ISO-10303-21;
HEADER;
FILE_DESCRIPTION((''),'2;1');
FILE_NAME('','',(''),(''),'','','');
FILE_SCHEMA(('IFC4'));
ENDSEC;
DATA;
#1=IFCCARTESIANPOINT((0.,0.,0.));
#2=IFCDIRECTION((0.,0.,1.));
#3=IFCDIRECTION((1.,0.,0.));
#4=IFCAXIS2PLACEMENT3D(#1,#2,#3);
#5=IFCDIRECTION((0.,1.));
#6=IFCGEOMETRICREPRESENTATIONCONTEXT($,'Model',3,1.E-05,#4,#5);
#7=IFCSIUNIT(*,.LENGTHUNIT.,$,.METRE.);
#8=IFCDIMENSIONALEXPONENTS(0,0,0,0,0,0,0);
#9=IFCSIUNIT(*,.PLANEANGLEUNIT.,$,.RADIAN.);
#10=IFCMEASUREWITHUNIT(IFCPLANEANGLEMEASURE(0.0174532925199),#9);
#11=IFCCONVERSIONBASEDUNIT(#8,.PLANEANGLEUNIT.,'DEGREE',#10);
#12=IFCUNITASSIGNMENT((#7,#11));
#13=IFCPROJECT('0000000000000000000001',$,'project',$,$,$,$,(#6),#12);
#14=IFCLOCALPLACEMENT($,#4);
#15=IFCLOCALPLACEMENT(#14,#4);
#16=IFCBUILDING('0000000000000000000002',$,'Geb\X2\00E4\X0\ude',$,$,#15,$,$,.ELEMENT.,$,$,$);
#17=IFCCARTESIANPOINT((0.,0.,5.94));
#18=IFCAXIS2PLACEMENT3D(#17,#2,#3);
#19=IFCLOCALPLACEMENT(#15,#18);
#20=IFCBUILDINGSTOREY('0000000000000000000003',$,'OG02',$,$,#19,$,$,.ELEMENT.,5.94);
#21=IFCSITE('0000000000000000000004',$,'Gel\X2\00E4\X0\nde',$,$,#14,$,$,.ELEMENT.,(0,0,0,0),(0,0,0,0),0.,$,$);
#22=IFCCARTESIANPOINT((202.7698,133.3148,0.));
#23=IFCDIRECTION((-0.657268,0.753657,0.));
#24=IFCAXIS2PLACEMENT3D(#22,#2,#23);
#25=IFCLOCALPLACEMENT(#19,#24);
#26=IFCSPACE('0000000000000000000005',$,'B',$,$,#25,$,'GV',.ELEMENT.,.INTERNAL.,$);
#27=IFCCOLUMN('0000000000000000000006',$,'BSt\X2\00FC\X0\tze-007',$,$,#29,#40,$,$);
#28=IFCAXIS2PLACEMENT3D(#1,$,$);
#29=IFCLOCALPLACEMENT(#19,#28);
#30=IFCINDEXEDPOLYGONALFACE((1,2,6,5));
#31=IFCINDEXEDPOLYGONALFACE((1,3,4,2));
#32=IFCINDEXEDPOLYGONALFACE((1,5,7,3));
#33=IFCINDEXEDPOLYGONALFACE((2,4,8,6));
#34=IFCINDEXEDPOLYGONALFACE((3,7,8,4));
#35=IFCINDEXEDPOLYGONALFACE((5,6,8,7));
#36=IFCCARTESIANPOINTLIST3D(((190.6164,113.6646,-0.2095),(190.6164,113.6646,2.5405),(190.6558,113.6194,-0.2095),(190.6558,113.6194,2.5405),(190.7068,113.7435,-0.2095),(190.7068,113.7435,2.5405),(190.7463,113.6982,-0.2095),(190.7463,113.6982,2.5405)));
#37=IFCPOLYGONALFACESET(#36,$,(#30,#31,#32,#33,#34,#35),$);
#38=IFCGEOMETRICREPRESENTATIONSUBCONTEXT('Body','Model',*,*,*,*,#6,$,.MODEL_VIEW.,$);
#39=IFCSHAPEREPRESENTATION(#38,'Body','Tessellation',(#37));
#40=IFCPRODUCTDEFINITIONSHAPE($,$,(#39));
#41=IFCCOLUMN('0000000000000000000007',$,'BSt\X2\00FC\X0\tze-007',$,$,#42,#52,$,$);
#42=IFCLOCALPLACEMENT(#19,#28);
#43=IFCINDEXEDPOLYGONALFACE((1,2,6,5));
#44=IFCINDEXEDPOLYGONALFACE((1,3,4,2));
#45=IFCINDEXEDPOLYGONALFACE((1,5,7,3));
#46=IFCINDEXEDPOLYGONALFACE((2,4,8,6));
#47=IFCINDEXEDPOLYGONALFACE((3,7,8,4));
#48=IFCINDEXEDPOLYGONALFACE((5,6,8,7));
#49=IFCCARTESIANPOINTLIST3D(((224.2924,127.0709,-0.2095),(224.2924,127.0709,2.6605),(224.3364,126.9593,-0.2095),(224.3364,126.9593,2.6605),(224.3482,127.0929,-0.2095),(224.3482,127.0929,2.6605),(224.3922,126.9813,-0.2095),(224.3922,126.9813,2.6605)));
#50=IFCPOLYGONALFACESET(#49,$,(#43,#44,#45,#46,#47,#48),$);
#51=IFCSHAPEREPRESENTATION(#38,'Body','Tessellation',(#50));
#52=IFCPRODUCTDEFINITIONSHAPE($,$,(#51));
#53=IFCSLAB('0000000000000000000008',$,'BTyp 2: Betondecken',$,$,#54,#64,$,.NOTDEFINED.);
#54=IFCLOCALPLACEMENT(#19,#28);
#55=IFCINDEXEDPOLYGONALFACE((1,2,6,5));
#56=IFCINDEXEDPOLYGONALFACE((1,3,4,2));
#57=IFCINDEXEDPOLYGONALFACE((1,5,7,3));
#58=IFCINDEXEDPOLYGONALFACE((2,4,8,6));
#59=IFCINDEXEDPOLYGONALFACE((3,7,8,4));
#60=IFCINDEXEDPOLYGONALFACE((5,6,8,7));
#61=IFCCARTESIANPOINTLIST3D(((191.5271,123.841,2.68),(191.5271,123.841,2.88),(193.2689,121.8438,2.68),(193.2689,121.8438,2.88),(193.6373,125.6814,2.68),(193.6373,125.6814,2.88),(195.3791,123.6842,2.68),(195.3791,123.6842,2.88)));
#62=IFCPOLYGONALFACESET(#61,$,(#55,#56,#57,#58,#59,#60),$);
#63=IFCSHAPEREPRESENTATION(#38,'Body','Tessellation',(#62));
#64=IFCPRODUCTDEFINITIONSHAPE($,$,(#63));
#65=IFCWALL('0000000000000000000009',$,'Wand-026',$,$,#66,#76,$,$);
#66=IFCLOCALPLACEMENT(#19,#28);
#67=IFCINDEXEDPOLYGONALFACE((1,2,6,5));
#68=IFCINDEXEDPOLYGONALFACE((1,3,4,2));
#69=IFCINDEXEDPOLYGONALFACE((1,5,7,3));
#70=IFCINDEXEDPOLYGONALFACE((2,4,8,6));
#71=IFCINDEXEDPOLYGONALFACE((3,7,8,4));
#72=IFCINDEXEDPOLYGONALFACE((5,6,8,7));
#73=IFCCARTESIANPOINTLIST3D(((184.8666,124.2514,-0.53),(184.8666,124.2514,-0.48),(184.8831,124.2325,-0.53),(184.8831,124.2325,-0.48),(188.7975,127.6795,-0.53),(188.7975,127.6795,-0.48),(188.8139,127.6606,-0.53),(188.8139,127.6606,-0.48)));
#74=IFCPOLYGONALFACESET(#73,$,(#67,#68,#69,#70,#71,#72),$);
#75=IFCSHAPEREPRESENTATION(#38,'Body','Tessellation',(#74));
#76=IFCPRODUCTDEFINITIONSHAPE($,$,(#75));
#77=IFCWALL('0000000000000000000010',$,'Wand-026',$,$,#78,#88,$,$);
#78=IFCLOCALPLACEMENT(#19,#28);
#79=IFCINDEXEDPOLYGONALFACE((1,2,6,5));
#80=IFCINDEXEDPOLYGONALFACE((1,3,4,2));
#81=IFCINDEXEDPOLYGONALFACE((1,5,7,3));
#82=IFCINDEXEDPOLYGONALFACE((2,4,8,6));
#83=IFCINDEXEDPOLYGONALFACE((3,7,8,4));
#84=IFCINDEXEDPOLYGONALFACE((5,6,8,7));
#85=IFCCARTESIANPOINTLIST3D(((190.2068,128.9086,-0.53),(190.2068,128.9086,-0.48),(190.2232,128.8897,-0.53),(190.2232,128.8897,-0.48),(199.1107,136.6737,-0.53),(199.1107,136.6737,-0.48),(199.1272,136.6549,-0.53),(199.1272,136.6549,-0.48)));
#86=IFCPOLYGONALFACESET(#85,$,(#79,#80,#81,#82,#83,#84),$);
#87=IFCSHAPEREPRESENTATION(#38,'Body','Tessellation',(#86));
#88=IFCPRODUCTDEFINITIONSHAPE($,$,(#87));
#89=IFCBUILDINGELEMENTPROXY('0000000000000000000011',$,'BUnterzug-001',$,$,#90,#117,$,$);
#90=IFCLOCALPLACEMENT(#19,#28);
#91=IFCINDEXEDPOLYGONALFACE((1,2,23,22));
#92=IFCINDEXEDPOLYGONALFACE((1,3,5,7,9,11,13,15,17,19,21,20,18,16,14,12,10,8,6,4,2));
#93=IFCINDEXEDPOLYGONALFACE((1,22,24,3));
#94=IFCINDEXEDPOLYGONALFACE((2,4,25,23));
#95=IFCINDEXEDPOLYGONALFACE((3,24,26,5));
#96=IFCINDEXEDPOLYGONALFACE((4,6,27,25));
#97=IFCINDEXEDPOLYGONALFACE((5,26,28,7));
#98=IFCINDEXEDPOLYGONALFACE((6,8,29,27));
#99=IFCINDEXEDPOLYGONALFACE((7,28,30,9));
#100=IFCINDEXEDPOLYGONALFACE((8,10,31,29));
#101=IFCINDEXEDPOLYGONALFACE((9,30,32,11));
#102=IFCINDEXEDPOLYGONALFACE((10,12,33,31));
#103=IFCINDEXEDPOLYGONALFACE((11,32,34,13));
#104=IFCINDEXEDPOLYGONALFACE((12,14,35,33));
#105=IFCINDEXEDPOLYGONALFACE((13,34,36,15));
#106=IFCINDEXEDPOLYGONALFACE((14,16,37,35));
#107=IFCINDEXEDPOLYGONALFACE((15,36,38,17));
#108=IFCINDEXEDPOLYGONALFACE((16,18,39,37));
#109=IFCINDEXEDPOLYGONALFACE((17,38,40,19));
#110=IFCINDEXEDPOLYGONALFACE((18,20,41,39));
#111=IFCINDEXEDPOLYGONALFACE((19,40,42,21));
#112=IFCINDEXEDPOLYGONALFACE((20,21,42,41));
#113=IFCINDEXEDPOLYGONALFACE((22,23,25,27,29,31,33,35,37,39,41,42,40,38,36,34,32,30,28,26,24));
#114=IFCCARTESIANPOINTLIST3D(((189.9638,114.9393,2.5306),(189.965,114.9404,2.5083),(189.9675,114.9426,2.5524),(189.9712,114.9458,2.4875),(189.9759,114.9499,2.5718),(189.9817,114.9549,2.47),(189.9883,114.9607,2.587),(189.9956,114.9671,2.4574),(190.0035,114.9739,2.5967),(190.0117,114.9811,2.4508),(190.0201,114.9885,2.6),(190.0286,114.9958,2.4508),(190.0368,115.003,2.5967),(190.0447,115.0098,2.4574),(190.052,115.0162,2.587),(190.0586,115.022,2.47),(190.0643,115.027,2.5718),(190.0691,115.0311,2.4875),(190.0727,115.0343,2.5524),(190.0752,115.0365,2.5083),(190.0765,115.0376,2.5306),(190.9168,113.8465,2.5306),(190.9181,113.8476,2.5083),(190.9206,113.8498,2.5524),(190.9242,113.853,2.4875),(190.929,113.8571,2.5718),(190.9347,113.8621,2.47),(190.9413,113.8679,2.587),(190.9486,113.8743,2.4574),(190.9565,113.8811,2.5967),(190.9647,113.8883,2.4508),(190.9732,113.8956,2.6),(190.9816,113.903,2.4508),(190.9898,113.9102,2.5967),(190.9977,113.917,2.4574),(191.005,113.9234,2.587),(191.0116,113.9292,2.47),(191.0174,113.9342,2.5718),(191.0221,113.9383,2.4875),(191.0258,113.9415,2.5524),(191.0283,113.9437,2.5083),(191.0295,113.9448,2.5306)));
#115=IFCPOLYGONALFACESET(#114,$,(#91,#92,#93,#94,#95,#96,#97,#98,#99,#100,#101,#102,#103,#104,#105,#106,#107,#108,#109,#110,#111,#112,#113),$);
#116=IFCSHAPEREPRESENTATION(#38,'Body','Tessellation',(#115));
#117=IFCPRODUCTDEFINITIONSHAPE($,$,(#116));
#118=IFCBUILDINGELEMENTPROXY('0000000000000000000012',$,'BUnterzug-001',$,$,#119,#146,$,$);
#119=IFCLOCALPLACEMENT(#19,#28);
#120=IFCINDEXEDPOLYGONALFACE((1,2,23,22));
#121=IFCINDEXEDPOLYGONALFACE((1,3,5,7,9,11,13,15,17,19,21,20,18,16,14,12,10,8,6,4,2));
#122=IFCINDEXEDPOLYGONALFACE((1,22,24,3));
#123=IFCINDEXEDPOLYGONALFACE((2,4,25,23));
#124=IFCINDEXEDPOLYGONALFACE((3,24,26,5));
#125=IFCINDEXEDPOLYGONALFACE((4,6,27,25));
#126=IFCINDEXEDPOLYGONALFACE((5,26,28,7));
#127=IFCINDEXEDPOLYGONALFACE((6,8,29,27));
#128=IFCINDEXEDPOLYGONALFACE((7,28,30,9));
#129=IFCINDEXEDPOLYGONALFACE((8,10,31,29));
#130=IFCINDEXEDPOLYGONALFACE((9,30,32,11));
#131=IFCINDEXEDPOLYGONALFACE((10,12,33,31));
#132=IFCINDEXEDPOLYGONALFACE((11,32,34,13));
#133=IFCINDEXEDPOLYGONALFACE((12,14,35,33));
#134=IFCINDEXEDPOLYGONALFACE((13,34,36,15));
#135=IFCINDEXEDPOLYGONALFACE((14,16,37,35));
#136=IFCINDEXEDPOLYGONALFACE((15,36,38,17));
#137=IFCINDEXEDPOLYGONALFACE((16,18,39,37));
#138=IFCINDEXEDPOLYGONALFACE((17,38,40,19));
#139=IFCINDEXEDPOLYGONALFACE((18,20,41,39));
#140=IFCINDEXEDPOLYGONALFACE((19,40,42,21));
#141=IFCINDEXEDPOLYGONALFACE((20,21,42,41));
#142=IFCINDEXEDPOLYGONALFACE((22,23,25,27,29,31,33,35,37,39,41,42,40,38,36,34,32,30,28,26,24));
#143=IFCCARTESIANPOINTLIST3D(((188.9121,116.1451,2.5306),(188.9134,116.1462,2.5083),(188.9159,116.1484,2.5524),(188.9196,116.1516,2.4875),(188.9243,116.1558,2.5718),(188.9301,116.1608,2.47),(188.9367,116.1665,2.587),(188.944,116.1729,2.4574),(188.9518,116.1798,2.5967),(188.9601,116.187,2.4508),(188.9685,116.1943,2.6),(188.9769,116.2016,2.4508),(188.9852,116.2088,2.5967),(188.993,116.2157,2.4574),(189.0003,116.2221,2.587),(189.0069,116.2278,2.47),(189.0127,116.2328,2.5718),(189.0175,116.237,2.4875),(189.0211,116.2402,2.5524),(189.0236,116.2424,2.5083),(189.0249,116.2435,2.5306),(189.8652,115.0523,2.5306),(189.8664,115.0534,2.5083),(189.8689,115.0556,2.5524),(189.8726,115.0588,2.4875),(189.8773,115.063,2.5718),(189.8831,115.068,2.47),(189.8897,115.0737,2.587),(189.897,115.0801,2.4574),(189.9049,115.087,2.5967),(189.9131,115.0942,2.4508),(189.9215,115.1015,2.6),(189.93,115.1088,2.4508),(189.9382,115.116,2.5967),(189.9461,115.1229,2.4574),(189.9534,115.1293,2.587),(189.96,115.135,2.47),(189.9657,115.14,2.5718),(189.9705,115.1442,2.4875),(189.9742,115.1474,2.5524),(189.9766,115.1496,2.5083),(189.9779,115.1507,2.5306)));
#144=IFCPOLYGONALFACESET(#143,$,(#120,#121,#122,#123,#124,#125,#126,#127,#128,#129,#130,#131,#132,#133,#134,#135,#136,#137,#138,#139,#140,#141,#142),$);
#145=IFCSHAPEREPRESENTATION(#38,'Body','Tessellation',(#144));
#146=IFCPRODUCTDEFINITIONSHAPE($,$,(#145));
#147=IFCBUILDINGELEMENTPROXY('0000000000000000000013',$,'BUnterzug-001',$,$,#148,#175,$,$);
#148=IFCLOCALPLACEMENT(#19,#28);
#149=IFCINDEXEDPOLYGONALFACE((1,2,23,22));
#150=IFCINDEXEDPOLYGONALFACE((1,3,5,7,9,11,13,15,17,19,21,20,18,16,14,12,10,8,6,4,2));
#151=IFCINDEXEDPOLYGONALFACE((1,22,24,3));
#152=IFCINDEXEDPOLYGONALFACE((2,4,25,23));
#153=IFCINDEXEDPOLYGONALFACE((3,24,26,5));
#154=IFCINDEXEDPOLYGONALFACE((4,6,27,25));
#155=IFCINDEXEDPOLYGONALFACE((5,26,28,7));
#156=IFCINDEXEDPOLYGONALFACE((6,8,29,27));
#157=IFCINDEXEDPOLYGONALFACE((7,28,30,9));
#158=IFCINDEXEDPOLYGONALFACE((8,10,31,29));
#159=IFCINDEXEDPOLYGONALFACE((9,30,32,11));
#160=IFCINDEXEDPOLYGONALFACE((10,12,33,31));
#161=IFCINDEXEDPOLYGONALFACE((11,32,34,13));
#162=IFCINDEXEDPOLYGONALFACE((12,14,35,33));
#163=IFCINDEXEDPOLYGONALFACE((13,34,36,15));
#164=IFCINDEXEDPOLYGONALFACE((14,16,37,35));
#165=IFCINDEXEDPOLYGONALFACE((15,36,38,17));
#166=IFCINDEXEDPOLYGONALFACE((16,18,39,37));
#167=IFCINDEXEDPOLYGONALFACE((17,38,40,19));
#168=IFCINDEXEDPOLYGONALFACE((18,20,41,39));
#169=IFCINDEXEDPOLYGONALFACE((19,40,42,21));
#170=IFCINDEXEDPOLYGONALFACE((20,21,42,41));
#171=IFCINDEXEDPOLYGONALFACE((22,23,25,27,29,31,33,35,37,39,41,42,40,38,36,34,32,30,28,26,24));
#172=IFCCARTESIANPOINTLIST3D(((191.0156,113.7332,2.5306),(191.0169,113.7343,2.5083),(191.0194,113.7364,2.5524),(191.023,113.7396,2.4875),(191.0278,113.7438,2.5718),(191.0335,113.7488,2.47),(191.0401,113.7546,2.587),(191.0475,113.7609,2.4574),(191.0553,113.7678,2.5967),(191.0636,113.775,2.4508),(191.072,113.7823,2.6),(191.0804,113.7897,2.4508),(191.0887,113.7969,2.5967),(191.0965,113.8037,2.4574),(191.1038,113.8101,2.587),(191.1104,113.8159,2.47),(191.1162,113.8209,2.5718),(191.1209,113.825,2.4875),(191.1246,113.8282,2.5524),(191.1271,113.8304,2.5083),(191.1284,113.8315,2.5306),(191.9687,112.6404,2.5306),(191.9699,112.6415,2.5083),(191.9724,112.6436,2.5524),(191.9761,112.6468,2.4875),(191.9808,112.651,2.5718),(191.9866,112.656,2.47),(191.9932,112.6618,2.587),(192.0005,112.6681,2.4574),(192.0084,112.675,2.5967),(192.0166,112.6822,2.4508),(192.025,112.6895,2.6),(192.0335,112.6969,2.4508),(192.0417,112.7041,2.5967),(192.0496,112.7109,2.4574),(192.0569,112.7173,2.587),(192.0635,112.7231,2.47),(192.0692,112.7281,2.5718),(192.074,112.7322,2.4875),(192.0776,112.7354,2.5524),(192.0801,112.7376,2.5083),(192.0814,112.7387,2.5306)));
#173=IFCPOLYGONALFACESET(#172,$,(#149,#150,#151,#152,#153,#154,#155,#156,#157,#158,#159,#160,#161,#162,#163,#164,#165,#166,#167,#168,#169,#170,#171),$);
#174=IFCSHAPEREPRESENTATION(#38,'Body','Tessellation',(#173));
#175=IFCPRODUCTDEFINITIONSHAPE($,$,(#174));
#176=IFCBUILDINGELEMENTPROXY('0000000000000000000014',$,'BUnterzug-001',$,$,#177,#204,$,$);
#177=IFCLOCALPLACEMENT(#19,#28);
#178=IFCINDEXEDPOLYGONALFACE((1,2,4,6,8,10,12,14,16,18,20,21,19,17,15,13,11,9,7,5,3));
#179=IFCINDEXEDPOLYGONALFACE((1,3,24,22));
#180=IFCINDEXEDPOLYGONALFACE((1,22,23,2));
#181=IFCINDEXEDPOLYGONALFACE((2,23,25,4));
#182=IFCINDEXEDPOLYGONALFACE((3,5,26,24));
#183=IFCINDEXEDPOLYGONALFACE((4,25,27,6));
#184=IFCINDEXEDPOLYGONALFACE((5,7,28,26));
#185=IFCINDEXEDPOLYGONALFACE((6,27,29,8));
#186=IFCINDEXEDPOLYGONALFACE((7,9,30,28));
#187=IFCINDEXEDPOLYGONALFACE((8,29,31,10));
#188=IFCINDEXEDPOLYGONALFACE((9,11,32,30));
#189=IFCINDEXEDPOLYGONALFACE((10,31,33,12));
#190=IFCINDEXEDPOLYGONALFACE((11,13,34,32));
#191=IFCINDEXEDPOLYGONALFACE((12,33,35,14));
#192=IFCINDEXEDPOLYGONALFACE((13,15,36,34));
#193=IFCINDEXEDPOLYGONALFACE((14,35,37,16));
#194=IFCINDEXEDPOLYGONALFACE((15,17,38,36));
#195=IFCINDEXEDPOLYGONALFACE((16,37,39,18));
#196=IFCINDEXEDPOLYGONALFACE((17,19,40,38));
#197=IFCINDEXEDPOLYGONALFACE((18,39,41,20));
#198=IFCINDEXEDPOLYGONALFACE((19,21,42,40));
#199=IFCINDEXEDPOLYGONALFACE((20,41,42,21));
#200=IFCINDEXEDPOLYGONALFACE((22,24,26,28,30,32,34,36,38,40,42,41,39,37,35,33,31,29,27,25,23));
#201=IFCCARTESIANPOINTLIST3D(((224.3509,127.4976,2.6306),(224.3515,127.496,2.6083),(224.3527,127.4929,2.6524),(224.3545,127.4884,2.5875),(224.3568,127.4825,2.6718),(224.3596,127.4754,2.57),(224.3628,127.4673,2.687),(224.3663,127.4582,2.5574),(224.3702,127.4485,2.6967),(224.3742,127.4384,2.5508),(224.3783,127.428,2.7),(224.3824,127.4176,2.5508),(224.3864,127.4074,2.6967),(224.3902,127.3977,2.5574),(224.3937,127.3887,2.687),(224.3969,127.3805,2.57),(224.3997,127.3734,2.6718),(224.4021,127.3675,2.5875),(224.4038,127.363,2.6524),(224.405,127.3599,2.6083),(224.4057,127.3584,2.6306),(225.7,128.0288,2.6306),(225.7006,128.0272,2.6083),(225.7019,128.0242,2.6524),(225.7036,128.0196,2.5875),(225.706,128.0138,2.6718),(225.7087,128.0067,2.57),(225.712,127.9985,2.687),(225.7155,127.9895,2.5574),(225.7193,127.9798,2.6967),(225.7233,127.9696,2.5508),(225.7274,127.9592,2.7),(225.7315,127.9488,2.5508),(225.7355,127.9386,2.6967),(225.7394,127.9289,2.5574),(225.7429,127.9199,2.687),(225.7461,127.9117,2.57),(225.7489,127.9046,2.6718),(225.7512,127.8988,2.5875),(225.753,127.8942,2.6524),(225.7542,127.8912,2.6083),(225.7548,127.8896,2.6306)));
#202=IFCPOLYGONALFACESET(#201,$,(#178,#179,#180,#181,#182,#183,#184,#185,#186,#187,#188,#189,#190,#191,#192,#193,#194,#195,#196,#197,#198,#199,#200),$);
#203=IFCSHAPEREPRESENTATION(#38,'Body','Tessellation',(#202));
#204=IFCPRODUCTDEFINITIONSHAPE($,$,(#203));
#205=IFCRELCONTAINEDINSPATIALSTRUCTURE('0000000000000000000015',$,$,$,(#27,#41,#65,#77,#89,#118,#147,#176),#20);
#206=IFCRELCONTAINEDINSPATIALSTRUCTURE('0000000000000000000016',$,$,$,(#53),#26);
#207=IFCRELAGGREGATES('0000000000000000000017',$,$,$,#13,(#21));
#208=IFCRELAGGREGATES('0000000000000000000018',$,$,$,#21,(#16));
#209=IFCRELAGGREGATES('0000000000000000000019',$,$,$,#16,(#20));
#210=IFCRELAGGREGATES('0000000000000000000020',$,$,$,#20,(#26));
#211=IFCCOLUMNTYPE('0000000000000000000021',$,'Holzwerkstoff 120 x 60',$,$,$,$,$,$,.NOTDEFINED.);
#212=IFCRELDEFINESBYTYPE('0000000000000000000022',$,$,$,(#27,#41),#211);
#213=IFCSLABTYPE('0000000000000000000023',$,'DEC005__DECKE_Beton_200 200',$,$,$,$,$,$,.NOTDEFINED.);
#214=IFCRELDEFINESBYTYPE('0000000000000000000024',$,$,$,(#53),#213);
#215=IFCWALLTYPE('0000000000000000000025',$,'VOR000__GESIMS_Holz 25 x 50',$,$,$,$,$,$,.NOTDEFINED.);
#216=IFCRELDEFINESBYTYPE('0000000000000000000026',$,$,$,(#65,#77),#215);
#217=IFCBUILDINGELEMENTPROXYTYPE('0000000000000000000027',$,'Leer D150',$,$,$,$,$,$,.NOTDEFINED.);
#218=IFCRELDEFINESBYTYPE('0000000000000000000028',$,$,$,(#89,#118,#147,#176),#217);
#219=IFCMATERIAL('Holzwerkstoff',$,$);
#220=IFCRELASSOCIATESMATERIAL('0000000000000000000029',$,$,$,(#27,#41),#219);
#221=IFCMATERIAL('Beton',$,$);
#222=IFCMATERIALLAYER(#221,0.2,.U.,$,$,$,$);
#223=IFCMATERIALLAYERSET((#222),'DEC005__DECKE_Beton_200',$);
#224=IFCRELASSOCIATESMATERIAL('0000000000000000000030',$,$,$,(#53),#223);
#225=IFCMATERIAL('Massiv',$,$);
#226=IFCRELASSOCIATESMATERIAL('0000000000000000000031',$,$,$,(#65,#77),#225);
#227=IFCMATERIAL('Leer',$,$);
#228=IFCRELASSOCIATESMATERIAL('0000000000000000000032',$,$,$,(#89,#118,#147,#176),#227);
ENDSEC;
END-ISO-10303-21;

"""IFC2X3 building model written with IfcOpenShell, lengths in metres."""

from ifc_helpers import new_model, entity, si_unit, converted_unit, direction, frame, frame_2d, origin_with_axes, origin_2d_with_axis, place, context, subcontext, project, spatial, polyline, rectangle, circle, outline, extrude, material, layer, layer_set, layer_usage, type_object, element, save


model = new_model("IFC2X3")

# Units and contexts
model_context = context("Model", 3, precision=1e-05, world=origin_with_axes(), true_north=direction((0.0, 1.0)))
body_context = subcontext(model_context, "Body", "Model", "MODEL_VIEW")
ifc_project = project(units=[si_unit("LENGTHUNIT", "METRE"), converted_unit("PLANEANGLEUNIT", "DEGREE", entity("IfcPlaneAngleMeasure", 0.0174532925199), si_unit("PLANEANGLEUNIT", "RADIAN"), dimensions=[0, 0, 0, 0, 0, 0, 0])], contexts=[model_context])

# Site, building, storey
site_placement = place(None, origin_with_axes())
site = spatial("IfcSite", under=ifc_project, at=site_placement, Name="Gelände", CompositionType="ELEMENT", RefLatitude=(0, 0, 0, 0), RefLongitude=(0, 0, 0, 0), RefElevation=0.0)
building_placement = place(site_placement, origin_with_axes())
building = spatial("IfcBuilding", under=site, at=building_placement, Name="Gebäude", CompositionType="ELEMENT")
storey_placement = place(building_placement, frame((0.0, 0.0, 5.94), z_axis=(0.0, 0.0, 1.0), x_axis=(1.0, 0.0, 0.0)))
storey = spatial("IfcBuildingStorey", under=building, at=storey_placement, Name="OG02", CompositionType="ELEMENT", Elevation=5.94)

# Columns
ifc_material_1 = material(Name="Holzwerkstoff")
column_type_1 = type_object("IfcColumnType", Name="Holzwerkstoff 120 x 60", PredefinedType="NOTDEFINED")
column_1_placement = place(storey_placement, frame((190.6813, 113.6814, -0.2095), z_axis=(0.0, 0.0, 1.0), x_axis=(-0.753657, -0.657268, 0.0)))
element("IfcColumn", 1, at=column_1_placement, inside=storey, type_object=column_type_1, material=ifc_material_1, Name="BStütze-007", context=body_context, shape_type="SweptSolid", body=[
    extrude(rectangle(XDim=0.12, YDim=0.06, at=origin_2d_with_axis()), origin_with_axes(), (0.0, 0.0, 1.0), 2.75),
])
column_2_placement = place(storey_placement, frame((224.3423, 127.0261, -0.2095), z_axis=(0.0, 0.0, 1.0), x_axis=(0.366369, -0.93047, 0.0)))
element("IfcColumn", 2, at=column_2_placement, inside=storey, type_object=column_type_1, material=ifc_material_1, Name="BStütze-007", context=body_context, shape_type="SweptSolid", body=[
    extrude(rectangle(XDim=0.12, YDim=0.06, at=origin_2d_with_axis()), origin_with_axes(), (0.0, 0.0, 1.0), 2.87),
])

# Shared definitions
space_1_placement = place(storey_placement, frame((202.7698, 133.3148, 0.0), z_axis=(0.0, 0.0, 1.0), x_axis=(-0.657268, 0.753657, 0.0)))
space_1 = spatial("IfcSpace", under=storey, at=space_1_placement, Name="B", LongName="GV", CompositionType="ELEMENT", InteriorOrExteriorSpace="INTERNAL")

# Slab
ifc_material_2 = material(Name="Beton")
ifc_layer_1 = layer(ifc_material_2, 0.2, ventilated="UNKNOWN")
ifc_layer_set_1 = layer_set([ifc_layer_1], Name="DEC005__DECKE_Beton_200")
ifc_layer_usage_1 = layer_usage(ifc_layer_set_1, "AXIS3", "NEGATIVE", 0.2)
slab_type_1 = type_object("IfcSlabType", Name="DEC005__DECKE_Beton_200 200", PredefinedType="NOTDEFINED")
slab_1_placement = place(space_1_placement, frame((0.2495, 11.9, 2.88), z_axis=(0.0, 0.0, 1.0), x_axis=(-0.657268, -0.753657, 0.0)))
element("IfcSlab", 3, at=slab_1_placement, inside=space_1, type_object=slab_type_1, material=ifc_layer_usage_1, Name="BTyp 2: Betondecken", PredefinedType="NOTDEFINED", context=body_context, shape_type="SweptSolid", body=[
    extrude(outline(polyline([(0.0, 0.0), (-2.1102, -1.8404), (-0.3685, -3.8375), (1.7418, -1.9972), (0.0, 0.0)])), frame((0.0, 0.0, -0.2), z_axis=(0.0, 0.0, 1.0), x_axis=(1.0, 0.0, 0.0)), (0.0, 0.0, 1.0), 0.2),
])

# Walls
ifc_material_3 = material(Name="Massiv")
wall_type = type_object("IfcWallType", Name="VOR000__GESIMS_Holz 25 x 50", PredefinedType="NOTDEFINED")
wall_1_placement = place(storey_placement, frame((188.8139, 127.6606, -0.505), z_axis=(0.0, 0.0, 1.0), x_axis=(-0.753657, -0.657268, 0.0)))
element("IfcWall", 4, at=wall_1_placement, inside=storey, type_object=wall_type, material=ifc_material_3, Name="Wand-026", context=body_context, shape_type="SweptSolid", body=[
    extrude(outline(polyline([(0.0, -0.025), (0.0, 0.025), (-0.025, 0.025), (-0.025, -0.025), (0.0, -0.025)])), frame((0.0, 0.0, 0.0), z_axis=(1.0, 0.0, 0.0), x_axis=(0.0, 1.0, 0.0)), (0.0, 0.0, 1.0), 5.2157),
])
wall_2_placement = place(storey_placement, frame((199.1272, 136.6549, -0.505), z_axis=(0.0, 0.0, 1.0), x_axis=(-0.753657, -0.657268, 0.0)))
element("IfcWall", 5, at=wall_2_placement, inside=storey, type_object=wall_type, material=ifc_material_3, Name="Wand-026", context=body_context, shape_type="SweptSolid", body=[
    extrude(outline(polyline([(0.0, -0.025), (0.0, 0.025), (-0.025, 0.025), (-0.025, -0.025), (0.0, -0.025)])), frame((0.0, 0.0, 0.0), z_axis=(1.0, 0.0, 0.0), x_axis=(0.0, 1.0, 0.0)), (0.0, 0.0, 1.0), 11.8143),
])

# Building element proxies
ifc_material_4 = material(Name="Leer")
building_element_proxy_type_1 = type_object("IfcBuildingElementProxyType", Name="Leer D150", PredefinedType="NOTDEFINED")
for number, where, z_axis, x_axis, name in (
    (6, (190.0201, 114.9885, 2.6), (0.0, 0.0, 1.0), (-0.753657, -0.657268, 0.0), "BUnterzug-001"),
    (7, (188.9685, 116.1943, 2.6), (0.0, 0.0, 1.0), (-0.753657, -0.657268, 0.0), "BUnterzug-001"),
    (8, (191.072, 113.7823, 2.6), (0.0, 0.0, 1.0), (-0.753657, -0.657268, 0.0), "BUnterzug-001"),
    (9, (224.3783, 127.428, 2.7), (0.0, 0.0, 1.0), (0.366369, -0.93047, 0.0), "BUnterzug-001"),
):
    element("IfcBuildingElementProxy", number, at=place(storey_placement, frame(where, z_axis=z_axis, x_axis=x_axis)), inside=storey, type_object=building_element_proxy_type_1, material=ifc_material_4, Name=name, context=body_context, shape_type="SweptSolid", body=[
        extrude(circle(Radius=0.075, at=frame_2d((-0.075, 0.0), x_axis=(1.0, 0.0))), frame((0.0, 0.0, 0.0), z_axis=(0.0, 1.0, 0.0), x_axis=(0.0, 0.0, 1.0)), (0.0, 0.0, 1.0), 1.45),
    ])

save(model, "model.ifc")
